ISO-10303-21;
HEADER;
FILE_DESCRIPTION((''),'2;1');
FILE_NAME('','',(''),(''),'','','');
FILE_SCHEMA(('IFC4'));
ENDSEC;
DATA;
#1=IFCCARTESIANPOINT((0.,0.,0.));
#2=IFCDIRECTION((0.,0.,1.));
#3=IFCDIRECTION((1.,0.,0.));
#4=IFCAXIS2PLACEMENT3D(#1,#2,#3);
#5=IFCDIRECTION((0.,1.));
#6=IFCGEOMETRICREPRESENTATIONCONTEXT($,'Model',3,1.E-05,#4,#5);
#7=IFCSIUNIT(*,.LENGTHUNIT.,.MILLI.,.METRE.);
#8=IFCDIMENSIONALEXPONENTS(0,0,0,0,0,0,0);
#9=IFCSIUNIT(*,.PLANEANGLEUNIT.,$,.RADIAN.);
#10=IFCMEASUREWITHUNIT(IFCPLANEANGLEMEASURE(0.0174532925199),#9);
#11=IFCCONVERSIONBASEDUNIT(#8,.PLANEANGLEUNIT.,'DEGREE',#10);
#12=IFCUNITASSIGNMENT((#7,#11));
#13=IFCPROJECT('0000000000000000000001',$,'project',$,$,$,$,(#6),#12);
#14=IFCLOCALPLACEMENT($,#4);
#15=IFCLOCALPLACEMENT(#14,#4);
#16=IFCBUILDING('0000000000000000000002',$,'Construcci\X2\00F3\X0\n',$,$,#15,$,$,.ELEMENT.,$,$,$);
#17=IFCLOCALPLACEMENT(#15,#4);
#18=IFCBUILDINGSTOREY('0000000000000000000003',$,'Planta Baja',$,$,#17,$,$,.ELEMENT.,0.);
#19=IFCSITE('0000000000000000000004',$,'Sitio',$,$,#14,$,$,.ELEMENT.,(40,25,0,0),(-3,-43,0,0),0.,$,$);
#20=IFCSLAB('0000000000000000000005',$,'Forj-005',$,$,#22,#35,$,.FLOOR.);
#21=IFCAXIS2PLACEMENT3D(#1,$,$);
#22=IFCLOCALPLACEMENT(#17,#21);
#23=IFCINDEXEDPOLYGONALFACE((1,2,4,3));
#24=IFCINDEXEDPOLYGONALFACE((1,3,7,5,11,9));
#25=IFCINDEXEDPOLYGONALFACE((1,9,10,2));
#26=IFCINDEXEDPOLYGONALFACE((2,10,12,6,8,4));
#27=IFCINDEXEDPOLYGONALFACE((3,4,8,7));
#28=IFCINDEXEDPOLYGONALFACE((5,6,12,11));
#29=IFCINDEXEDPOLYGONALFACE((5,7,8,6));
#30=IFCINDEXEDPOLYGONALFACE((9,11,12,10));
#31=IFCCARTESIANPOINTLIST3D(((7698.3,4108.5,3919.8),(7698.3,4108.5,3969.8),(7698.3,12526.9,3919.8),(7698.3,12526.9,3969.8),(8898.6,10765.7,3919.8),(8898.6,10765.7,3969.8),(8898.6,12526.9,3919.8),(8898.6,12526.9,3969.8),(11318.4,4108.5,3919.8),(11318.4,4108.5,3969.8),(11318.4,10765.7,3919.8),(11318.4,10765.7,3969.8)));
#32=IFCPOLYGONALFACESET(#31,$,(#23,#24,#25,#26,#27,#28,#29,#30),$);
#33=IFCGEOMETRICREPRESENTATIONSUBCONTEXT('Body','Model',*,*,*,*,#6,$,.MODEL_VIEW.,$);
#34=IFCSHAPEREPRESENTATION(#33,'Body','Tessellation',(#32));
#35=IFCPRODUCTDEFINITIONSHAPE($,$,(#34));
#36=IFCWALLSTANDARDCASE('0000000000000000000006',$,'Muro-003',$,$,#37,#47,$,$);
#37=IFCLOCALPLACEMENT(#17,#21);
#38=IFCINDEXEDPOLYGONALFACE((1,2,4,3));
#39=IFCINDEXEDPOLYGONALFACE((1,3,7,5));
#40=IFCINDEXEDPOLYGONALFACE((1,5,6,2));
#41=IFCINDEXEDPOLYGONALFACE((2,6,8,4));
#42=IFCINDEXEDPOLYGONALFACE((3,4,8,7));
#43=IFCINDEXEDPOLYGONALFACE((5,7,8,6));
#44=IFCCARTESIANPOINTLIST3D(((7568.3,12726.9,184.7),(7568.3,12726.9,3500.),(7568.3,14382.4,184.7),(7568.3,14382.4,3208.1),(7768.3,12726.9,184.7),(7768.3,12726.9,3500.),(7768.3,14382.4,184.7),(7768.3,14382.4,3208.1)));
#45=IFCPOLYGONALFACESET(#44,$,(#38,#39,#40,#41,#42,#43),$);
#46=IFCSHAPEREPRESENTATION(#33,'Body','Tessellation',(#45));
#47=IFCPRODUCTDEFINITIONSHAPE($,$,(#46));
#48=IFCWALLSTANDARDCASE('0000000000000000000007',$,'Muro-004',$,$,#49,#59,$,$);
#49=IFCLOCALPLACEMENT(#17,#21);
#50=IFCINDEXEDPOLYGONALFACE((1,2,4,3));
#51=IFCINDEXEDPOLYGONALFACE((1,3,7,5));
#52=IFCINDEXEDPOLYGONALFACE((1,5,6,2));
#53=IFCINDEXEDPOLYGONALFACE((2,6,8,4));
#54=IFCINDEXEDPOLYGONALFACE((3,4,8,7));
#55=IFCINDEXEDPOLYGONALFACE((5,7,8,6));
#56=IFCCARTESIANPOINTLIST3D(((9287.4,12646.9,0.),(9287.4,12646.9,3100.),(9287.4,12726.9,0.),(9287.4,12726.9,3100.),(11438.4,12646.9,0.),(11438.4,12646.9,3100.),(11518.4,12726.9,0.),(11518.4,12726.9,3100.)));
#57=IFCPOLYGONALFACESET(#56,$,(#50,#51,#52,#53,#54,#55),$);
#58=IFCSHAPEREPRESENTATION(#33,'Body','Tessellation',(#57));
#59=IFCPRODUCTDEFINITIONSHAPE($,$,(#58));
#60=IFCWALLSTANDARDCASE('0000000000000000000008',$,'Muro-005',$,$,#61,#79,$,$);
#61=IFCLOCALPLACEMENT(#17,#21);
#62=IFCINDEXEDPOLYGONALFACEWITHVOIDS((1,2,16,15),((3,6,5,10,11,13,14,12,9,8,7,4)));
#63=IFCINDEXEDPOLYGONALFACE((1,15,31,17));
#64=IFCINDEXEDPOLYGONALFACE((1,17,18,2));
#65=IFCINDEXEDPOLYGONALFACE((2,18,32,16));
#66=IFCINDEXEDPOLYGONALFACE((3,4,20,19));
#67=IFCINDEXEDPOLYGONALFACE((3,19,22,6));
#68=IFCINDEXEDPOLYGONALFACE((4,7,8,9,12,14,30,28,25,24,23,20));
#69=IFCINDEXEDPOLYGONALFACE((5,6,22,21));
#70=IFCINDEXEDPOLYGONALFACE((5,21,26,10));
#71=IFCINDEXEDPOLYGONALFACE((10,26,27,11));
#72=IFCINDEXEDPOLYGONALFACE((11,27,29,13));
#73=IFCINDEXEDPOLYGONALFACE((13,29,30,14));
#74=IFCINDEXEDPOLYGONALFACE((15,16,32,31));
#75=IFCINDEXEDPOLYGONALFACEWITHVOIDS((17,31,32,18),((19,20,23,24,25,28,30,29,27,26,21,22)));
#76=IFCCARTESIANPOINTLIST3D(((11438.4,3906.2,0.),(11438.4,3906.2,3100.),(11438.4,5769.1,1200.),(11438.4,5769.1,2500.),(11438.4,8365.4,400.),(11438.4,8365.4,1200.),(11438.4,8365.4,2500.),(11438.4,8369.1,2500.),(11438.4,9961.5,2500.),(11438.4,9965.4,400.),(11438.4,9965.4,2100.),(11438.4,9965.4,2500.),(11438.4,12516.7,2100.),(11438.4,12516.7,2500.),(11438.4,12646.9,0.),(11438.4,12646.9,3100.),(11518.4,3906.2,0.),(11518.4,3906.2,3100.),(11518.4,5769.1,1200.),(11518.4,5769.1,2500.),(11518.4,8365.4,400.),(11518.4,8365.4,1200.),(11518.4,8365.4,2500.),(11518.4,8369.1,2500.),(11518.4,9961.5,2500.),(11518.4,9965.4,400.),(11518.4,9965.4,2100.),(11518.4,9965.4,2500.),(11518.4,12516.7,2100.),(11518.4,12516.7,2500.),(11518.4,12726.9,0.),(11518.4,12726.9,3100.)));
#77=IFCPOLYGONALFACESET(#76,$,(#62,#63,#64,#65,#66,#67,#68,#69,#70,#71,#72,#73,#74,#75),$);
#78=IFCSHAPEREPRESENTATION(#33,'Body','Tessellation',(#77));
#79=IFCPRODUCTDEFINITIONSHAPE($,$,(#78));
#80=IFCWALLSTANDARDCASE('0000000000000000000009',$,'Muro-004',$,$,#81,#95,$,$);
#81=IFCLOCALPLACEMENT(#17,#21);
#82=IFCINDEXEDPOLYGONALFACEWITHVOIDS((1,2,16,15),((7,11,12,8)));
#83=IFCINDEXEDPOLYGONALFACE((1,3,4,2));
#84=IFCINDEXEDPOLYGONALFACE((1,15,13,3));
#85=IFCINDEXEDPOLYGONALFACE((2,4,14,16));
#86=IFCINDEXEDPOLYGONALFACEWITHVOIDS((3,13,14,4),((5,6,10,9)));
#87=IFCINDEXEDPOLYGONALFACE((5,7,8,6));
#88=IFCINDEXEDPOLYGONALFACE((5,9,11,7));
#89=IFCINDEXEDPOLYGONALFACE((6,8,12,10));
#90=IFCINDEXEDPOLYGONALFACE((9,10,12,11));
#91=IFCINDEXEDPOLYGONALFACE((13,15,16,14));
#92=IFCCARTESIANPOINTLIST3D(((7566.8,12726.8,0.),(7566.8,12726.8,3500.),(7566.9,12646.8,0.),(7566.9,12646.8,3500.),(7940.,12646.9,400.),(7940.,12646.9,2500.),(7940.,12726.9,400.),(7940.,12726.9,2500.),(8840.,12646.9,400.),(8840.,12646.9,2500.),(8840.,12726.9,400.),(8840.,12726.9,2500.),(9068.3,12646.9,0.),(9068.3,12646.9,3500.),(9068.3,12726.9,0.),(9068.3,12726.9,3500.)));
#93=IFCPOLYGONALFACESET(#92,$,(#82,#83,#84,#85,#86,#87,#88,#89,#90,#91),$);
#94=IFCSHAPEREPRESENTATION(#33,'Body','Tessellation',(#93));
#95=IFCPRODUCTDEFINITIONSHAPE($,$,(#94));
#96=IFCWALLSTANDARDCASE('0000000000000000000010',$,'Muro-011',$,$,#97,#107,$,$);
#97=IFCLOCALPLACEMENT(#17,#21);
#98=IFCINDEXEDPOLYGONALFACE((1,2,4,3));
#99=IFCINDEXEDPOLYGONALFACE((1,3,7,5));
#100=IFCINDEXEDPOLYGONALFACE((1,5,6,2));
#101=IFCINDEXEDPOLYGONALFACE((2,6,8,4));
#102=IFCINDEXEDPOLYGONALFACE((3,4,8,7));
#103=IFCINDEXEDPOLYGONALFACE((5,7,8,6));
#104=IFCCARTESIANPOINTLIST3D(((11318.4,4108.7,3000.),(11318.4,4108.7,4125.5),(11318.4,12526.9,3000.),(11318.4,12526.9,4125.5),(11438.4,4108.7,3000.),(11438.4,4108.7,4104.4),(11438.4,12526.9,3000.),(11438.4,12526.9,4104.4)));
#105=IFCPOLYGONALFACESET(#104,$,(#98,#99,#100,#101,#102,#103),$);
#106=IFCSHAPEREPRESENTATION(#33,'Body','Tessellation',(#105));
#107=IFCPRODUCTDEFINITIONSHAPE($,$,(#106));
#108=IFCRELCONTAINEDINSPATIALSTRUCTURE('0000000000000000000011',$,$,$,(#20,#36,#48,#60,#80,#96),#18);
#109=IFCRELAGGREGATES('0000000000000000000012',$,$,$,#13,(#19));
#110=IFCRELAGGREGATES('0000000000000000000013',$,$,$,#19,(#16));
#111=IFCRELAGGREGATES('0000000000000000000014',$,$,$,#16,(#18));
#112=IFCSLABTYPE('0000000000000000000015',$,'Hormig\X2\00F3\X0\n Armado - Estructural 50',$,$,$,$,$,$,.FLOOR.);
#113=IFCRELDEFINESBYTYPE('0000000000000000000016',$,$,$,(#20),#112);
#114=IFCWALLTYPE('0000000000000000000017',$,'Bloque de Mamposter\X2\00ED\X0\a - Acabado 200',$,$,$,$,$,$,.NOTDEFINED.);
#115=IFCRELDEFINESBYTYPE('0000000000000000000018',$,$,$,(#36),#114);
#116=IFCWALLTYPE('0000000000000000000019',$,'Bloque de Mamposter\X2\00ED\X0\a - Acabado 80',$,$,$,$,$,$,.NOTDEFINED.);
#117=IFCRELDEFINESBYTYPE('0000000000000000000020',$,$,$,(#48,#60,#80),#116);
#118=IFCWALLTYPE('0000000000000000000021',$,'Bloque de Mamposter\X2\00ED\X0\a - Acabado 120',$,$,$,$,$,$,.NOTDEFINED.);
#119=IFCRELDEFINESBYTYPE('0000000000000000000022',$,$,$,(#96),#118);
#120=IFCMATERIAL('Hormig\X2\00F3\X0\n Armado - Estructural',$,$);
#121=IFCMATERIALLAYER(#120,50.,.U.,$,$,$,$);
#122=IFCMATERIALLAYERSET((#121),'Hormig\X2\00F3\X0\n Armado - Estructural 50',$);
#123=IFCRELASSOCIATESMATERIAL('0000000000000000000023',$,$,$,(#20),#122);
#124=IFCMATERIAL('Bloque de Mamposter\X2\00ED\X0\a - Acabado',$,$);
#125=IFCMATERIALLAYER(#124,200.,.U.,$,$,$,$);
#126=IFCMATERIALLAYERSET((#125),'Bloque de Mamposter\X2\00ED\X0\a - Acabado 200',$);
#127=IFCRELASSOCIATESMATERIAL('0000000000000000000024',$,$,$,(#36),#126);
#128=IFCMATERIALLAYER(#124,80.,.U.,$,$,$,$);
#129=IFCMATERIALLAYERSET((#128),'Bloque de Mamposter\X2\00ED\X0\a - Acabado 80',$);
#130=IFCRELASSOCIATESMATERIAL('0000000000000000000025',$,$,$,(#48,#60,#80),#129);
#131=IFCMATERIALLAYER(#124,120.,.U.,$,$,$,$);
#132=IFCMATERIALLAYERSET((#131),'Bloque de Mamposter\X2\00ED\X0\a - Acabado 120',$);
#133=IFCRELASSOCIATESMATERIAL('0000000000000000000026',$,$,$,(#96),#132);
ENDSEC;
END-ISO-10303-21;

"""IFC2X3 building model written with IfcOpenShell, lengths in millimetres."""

from ifc_helpers import new_model, entity, si_unit, converted_unit, direction, frame, origin_with_axes, origin_2d_with_axis, place, context, subcontext, project, spatial, polyline, rectangle, outline, extrude, clip, halfspace, material, layer, layer_set, layer_usage, type_object, element, save


model = new_model("IFC2X3")

# Units and contexts
model_context = context("Model", 3, precision=1e-05, world=origin_with_axes(), true_north=direction((0.0, 1.0)))
body_context = subcontext(model_context, "Body", "Model", "MODEL_VIEW")
ifc_project = project(units=[si_unit("LENGTHUNIT", "METRE", prefix="MILLI"), converted_unit("PLANEANGLEUNIT", "DEGREE", entity("IfcPlaneAngleMeasure", 0.0174532925199), si_unit("PLANEANGLEUNIT", "RADIAN"), dimensions=[0, 0, 0, 0, 0, 0, 0])], contexts=[model_context])

# Site, building, storey
site_placement = place(None, origin_with_axes())
site = spatial("IfcSite", under=ifc_project, at=site_placement, Name="Sitio", CompositionType="ELEMENT", RefLatitude=(40, 25, 0, 0), RefLongitude=(-3, -43, 0, 0), RefElevation=0.0)
building_placement = place(site_placement, origin_with_axes())
building = spatial("IfcBuilding", under=site, at=building_placement, Name="Construcción", CompositionType="ELEMENT")
storey_placement = place(building_placement, origin_with_axes())
storey = spatial("IfcBuildingStorey", under=building, at=storey_placement, Name="Planta Baja", CompositionType="ELEMENT", Elevation=0.0)

# Shared definitions
ifc_material_1 = material(Name="Hormigón Armado - Estructural")

# Slab
ifc_layer_1 = layer(ifc_material_1, 50.0, ventilated="UNKNOWN")
ifc_layer_set_1 = layer_set([ifc_layer_1], Name="Hormigón Armado - Estructural 50")
slab_type_1 = type_object("IfcSlabType", Name="Hormigón Armado - Estructural 50", PredefinedType="FLOOR")
ifc_layer_usage_1 = layer_usage(ifc_layer_set_1, "AXIS3", "NEGATIVE", 50.0)
slab_1_placement = place(storey_placement, frame((7698.3, 12526.9, 3969.8), z_axis=(0.0, 0.0, 1.0), x_axis=(1.0, 0.0, 0.0)))
element("IfcSlab", 1, at=slab_1_placement, inside=storey, type_object=slab_type_1, material=ifc_layer_usage_1, Name="Forj-005", PredefinedType="FLOOR", context=body_context, shape_type="SweptSolid", body=[
    extrude(outline(polyline([(0.0, 0.0), (0.0, -8418.4), (3620.1, -8418.4), (3620.1, -1761.2), (1200.3, -1761.2), (1200.3, 0.0), (0.0, 0.0)])), frame((0.0, 0.0, -50.0), z_axis=(0.0, 0.0, 1.0), x_axis=(1.0, 0.0, 0.0)), (0.0, 0.0, 1.0), 50.0),
])

# Shared definitions
ifc_material_2 = material(Name="Bloque de Mampostería - Acabado")
ifc_layer_2 = layer(ifc_material_2, 200.0, ventilated="UNKNOWN")
ifc_layer_set_2 = layer_set([ifc_layer_2], Name="Bloque de Mampostería - Acabado 200")
wall_type_1 = type_object("IfcWallType", Name="Bloque de Mampostería - Acabado 200", PredefinedType="NOTDEFINED")

# Walls
ifc_layer_usage_2 = layer_usage(ifc_layer_set_2, "AXIS2", "POSITIVE", -200.0)
wall_1_placement = place(storey_placement, frame((7768.3, 14382.4, 184.7), z_axis=(0.0, 0.0, 1.0), x_axis=(0.000004, -1.0, 0.0)))
element("IfcWallStandardCase", 2, at=wall_1_placement, inside=storey, type_object=wall_type_1, material=ifc_layer_usage_2, Name="Muro-003", context=body_context, shape_type="Clipping", body=[
    clip(clip(extrude(outline(polyline([(0.0, -200.0), (1655.5, -200.0), (1655.5, 0.0), (0.0, 0.0), (0.0, -200.0)])), origin_with_axes(), (0.0, 0.0, 1.0), 5000.0), halfspace(frame((-517.0, 0.0, 2932.3), z_axis=(0.173648, -0.000001, -0.984808), x_axis=(0.0, 1.0, -0.000001)), True)), halfspace(frame((-517.0, 0.0, 2932.3), z_axis=(0.173648, -0.000001, -0.984808), x_axis=(0.0, 1.0, -0.000001)), True)),
])
ifc_layer_3 = layer(ifc_material_2, 80.0, ventilated="UNKNOWN")
ifc_layer_set_3 = layer_set([ifc_layer_3], Name="Bloque de Mampostería - Acabado 80")
ifc_layer_usage_3 = layer_usage(ifc_layer_set_3, "AXIS2", "POSITIVE", -80.0)
wall_type_2 = type_object("IfcWallType", Name="Bloque de Mampostería - Acabado 80", PredefinedType="NOTDEFINED")
wall_2_placement = place(storey_placement, frame((9287.4, 12726.9, 0.0), z_axis=(0.0, 0.0, 1.0), x_axis=(1.0, 0.000004, 0.0)))
element("IfcWallStandardCase", 3, at=wall_2_placement, inside=storey, type_object=wall_type_2, material=ifc_layer_usage_3, Name="Muro-004", context=body_context, shape_type="SweptSolid", body=[
    extrude(outline(polyline([(0.0, -80.0), (2150.9, -80.0), (2230.9, 0.0), (0.0, 0.0), (0.0, -80.0)])), origin_with_axes(), (0.0, 0.0, 1.0), 3100.0),
])

# Wall, openings
ifc_layer_usage_4 = layer_usage(ifc_layer_set_3, "AXIS2", "POSITIVE", -80.0)
wall_3_placement = place(storey_placement, frame((11518.4, 12726.9, 0.0), z_axis=(0.0, 0.0, 1.0), x_axis=(0.0, -1.0, 0.0)))
wall_3 = element("IfcWallStandardCase", 4, at=wall_3_placement, inside=storey, type_object=wall_type_2, material=ifc_layer_usage_4, Name="Muro-005", context=body_context, shape_type="SweptSolid", body=[
    extrude(outline(polyline([(80.0, -80.0), (8820.7, -80.0), (8820.7, 0.0), (0.0, 0.0), (80.0, -80.0)])), origin_with_axes(), (0.0, 0.0, 1.0), 3100.0),
])
opening_1_placement = place(wall_3_placement, frame((5657.8, 0.0, 1200.0), z_axis=(0.0, 0.0, 1.0), x_axis=(1.0, 0.0, 0.0)))
element("IfcOpeningElement", 5, at=opening_1_placement, cuts=wall_3, context=body_context, shape_type="SweptSolid", body=[
    extrude(rectangle(XDim=2600.0, YDim=1300.0, at=origin_2d_with_axis()), frame((0.0, -80.0, 650.0), z_axis=(0.0, 1.0, 0.0), x_axis=(-1.0, 0.0, 0.0)), (0.0, 0.0, 1.0), 240.0),
])
opening_2_placement = place(wall_3_placement, frame((3561.5, 0.0, 400.0), z_axis=(0.0, 0.0, 1.0), x_axis=(1.0, 0.0, 0.0)))
element("IfcOpeningElement", 6, at=opening_2_placement, cuts=wall_3, context=body_context, shape_type="SweptSolid", body=[
    extrude(rectangle(XDim=1600.0, YDim=2100.0, at=origin_2d_with_axis()), frame((0.0, 80.0, 1050.0), z_axis=(0.0, -1.0, 0.0), x_axis=(1.0, 0.0, 0.0)), (0.0, 0.0, 1.0), 240.0),
])
opening_3_placement = place(wall_3_placement, frame((1487.9, 0.0, 2100.0), z_axis=(0.0, 0.0, 1.0), x_axis=(1.0, 0.0, 0.0)))
element("IfcOpeningElement", 7, at=opening_3_placement, cuts=wall_3, context=body_context, shape_type="SweptSolid", body=[
    extrude(rectangle(XDim=2555.2, YDim=400.0, at=origin_2d_with_axis()), frame((0.0, -80.0, 200.0), z_axis=(0.0, 1.0, 0.0), x_axis=(-1.0, 0.0, 0.0)), (0.0, 0.0, 1.0), 240.0),
])

# Wall, opening
ifc_layer_usage_5 = layer_usage(ifc_layer_set_3, "AXIS2", "POSITIVE", -80.0)
wall_4_placement = place(storey_placement, frame((7566.8, 12726.8, 0.0), z_axis=(0.0, 0.0, 1.0), x_axis=(1.0, 0.000056, 0.0)))
wall_4 = element("IfcWallStandardCase", 8, at=wall_4_placement, inside=storey, type_object=wall_type_2, material=ifc_layer_usage_5, Name="Muro-004", context=body_context, shape_type="SweptSolid", body=[
    extrude(outline(polyline([(0.0, -80.0), (1501.5, -80.0), (1501.5, 0.0), (0.0, 0.0), (0.0, -80.0)])), origin_with_axes(), (0.0, 0.0, 1.0), 3500.0),
])
opening_4_placement = place(wall_4_placement, frame((823.2, 0.0, 400.0), z_axis=(0.0, 0.0, 1.0), x_axis=(1.0, 0.0, 0.0)))
element("IfcOpeningElement", 9, at=opening_4_placement, cuts=wall_4, context=body_context, shape_type="SweptSolid", body=[
    extrude(rectangle(XDim=900.0, YDim=2100.0, at=origin_2d_with_axis()), frame((0.0, -80.0, 1050.0), z_axis=(0.0, -1.0, 0.0), x_axis=(1.0, 0.0, 0.0)), (0.0, 0.0, -1.0), 240.0),
])
ifc_layer_4 = layer(ifc_material_2, 120.0, ventilated="UNKNOWN")
ifc_layer_set_4 = layer_set([ifc_layer_4], Name="Bloque de Mampostería - Acabado 120")
wall_type_3 = type_object("IfcWallType", Name="Bloque de Mampostería - Acabado 120", PredefinedType="NOTDEFINED")

# Wall
ifc_layer_usage_6 = layer_usage(ifc_layer_set_4, "AXIS2", "POSITIVE", 0.0)
wall_5_placement = place(storey_placement, frame((11318.4, 12526.9, 3000.0), z_axis=(0.0, 0.0, 1.0), x_axis=(0.000004, -1.0, 0.0)))
element("IfcWallStandardCase", 10, at=wall_5_placement, inside=storey, type_object=wall_type_3, material=ifc_layer_usage_6, Name="Muro-011", context=body_context, shape_type="Clipping", body=[
    clip(extrude(outline(polyline([(0.0, 0.0), (8418.3, 0.0), (8418.3, 120.0), (0.0, 120.0), (0.0, 0.0)])), origin_with_axes(), (0.0, 0.0, 1.0), 5000.0), halfspace(frame((0.0, 192.5, 1091.6), z_axis=(-0.000001, -0.173648, -0.984808), x_axis=(0.0, 0.984808, -0.173648)), True)),
])

save(model, "model.ifc")
